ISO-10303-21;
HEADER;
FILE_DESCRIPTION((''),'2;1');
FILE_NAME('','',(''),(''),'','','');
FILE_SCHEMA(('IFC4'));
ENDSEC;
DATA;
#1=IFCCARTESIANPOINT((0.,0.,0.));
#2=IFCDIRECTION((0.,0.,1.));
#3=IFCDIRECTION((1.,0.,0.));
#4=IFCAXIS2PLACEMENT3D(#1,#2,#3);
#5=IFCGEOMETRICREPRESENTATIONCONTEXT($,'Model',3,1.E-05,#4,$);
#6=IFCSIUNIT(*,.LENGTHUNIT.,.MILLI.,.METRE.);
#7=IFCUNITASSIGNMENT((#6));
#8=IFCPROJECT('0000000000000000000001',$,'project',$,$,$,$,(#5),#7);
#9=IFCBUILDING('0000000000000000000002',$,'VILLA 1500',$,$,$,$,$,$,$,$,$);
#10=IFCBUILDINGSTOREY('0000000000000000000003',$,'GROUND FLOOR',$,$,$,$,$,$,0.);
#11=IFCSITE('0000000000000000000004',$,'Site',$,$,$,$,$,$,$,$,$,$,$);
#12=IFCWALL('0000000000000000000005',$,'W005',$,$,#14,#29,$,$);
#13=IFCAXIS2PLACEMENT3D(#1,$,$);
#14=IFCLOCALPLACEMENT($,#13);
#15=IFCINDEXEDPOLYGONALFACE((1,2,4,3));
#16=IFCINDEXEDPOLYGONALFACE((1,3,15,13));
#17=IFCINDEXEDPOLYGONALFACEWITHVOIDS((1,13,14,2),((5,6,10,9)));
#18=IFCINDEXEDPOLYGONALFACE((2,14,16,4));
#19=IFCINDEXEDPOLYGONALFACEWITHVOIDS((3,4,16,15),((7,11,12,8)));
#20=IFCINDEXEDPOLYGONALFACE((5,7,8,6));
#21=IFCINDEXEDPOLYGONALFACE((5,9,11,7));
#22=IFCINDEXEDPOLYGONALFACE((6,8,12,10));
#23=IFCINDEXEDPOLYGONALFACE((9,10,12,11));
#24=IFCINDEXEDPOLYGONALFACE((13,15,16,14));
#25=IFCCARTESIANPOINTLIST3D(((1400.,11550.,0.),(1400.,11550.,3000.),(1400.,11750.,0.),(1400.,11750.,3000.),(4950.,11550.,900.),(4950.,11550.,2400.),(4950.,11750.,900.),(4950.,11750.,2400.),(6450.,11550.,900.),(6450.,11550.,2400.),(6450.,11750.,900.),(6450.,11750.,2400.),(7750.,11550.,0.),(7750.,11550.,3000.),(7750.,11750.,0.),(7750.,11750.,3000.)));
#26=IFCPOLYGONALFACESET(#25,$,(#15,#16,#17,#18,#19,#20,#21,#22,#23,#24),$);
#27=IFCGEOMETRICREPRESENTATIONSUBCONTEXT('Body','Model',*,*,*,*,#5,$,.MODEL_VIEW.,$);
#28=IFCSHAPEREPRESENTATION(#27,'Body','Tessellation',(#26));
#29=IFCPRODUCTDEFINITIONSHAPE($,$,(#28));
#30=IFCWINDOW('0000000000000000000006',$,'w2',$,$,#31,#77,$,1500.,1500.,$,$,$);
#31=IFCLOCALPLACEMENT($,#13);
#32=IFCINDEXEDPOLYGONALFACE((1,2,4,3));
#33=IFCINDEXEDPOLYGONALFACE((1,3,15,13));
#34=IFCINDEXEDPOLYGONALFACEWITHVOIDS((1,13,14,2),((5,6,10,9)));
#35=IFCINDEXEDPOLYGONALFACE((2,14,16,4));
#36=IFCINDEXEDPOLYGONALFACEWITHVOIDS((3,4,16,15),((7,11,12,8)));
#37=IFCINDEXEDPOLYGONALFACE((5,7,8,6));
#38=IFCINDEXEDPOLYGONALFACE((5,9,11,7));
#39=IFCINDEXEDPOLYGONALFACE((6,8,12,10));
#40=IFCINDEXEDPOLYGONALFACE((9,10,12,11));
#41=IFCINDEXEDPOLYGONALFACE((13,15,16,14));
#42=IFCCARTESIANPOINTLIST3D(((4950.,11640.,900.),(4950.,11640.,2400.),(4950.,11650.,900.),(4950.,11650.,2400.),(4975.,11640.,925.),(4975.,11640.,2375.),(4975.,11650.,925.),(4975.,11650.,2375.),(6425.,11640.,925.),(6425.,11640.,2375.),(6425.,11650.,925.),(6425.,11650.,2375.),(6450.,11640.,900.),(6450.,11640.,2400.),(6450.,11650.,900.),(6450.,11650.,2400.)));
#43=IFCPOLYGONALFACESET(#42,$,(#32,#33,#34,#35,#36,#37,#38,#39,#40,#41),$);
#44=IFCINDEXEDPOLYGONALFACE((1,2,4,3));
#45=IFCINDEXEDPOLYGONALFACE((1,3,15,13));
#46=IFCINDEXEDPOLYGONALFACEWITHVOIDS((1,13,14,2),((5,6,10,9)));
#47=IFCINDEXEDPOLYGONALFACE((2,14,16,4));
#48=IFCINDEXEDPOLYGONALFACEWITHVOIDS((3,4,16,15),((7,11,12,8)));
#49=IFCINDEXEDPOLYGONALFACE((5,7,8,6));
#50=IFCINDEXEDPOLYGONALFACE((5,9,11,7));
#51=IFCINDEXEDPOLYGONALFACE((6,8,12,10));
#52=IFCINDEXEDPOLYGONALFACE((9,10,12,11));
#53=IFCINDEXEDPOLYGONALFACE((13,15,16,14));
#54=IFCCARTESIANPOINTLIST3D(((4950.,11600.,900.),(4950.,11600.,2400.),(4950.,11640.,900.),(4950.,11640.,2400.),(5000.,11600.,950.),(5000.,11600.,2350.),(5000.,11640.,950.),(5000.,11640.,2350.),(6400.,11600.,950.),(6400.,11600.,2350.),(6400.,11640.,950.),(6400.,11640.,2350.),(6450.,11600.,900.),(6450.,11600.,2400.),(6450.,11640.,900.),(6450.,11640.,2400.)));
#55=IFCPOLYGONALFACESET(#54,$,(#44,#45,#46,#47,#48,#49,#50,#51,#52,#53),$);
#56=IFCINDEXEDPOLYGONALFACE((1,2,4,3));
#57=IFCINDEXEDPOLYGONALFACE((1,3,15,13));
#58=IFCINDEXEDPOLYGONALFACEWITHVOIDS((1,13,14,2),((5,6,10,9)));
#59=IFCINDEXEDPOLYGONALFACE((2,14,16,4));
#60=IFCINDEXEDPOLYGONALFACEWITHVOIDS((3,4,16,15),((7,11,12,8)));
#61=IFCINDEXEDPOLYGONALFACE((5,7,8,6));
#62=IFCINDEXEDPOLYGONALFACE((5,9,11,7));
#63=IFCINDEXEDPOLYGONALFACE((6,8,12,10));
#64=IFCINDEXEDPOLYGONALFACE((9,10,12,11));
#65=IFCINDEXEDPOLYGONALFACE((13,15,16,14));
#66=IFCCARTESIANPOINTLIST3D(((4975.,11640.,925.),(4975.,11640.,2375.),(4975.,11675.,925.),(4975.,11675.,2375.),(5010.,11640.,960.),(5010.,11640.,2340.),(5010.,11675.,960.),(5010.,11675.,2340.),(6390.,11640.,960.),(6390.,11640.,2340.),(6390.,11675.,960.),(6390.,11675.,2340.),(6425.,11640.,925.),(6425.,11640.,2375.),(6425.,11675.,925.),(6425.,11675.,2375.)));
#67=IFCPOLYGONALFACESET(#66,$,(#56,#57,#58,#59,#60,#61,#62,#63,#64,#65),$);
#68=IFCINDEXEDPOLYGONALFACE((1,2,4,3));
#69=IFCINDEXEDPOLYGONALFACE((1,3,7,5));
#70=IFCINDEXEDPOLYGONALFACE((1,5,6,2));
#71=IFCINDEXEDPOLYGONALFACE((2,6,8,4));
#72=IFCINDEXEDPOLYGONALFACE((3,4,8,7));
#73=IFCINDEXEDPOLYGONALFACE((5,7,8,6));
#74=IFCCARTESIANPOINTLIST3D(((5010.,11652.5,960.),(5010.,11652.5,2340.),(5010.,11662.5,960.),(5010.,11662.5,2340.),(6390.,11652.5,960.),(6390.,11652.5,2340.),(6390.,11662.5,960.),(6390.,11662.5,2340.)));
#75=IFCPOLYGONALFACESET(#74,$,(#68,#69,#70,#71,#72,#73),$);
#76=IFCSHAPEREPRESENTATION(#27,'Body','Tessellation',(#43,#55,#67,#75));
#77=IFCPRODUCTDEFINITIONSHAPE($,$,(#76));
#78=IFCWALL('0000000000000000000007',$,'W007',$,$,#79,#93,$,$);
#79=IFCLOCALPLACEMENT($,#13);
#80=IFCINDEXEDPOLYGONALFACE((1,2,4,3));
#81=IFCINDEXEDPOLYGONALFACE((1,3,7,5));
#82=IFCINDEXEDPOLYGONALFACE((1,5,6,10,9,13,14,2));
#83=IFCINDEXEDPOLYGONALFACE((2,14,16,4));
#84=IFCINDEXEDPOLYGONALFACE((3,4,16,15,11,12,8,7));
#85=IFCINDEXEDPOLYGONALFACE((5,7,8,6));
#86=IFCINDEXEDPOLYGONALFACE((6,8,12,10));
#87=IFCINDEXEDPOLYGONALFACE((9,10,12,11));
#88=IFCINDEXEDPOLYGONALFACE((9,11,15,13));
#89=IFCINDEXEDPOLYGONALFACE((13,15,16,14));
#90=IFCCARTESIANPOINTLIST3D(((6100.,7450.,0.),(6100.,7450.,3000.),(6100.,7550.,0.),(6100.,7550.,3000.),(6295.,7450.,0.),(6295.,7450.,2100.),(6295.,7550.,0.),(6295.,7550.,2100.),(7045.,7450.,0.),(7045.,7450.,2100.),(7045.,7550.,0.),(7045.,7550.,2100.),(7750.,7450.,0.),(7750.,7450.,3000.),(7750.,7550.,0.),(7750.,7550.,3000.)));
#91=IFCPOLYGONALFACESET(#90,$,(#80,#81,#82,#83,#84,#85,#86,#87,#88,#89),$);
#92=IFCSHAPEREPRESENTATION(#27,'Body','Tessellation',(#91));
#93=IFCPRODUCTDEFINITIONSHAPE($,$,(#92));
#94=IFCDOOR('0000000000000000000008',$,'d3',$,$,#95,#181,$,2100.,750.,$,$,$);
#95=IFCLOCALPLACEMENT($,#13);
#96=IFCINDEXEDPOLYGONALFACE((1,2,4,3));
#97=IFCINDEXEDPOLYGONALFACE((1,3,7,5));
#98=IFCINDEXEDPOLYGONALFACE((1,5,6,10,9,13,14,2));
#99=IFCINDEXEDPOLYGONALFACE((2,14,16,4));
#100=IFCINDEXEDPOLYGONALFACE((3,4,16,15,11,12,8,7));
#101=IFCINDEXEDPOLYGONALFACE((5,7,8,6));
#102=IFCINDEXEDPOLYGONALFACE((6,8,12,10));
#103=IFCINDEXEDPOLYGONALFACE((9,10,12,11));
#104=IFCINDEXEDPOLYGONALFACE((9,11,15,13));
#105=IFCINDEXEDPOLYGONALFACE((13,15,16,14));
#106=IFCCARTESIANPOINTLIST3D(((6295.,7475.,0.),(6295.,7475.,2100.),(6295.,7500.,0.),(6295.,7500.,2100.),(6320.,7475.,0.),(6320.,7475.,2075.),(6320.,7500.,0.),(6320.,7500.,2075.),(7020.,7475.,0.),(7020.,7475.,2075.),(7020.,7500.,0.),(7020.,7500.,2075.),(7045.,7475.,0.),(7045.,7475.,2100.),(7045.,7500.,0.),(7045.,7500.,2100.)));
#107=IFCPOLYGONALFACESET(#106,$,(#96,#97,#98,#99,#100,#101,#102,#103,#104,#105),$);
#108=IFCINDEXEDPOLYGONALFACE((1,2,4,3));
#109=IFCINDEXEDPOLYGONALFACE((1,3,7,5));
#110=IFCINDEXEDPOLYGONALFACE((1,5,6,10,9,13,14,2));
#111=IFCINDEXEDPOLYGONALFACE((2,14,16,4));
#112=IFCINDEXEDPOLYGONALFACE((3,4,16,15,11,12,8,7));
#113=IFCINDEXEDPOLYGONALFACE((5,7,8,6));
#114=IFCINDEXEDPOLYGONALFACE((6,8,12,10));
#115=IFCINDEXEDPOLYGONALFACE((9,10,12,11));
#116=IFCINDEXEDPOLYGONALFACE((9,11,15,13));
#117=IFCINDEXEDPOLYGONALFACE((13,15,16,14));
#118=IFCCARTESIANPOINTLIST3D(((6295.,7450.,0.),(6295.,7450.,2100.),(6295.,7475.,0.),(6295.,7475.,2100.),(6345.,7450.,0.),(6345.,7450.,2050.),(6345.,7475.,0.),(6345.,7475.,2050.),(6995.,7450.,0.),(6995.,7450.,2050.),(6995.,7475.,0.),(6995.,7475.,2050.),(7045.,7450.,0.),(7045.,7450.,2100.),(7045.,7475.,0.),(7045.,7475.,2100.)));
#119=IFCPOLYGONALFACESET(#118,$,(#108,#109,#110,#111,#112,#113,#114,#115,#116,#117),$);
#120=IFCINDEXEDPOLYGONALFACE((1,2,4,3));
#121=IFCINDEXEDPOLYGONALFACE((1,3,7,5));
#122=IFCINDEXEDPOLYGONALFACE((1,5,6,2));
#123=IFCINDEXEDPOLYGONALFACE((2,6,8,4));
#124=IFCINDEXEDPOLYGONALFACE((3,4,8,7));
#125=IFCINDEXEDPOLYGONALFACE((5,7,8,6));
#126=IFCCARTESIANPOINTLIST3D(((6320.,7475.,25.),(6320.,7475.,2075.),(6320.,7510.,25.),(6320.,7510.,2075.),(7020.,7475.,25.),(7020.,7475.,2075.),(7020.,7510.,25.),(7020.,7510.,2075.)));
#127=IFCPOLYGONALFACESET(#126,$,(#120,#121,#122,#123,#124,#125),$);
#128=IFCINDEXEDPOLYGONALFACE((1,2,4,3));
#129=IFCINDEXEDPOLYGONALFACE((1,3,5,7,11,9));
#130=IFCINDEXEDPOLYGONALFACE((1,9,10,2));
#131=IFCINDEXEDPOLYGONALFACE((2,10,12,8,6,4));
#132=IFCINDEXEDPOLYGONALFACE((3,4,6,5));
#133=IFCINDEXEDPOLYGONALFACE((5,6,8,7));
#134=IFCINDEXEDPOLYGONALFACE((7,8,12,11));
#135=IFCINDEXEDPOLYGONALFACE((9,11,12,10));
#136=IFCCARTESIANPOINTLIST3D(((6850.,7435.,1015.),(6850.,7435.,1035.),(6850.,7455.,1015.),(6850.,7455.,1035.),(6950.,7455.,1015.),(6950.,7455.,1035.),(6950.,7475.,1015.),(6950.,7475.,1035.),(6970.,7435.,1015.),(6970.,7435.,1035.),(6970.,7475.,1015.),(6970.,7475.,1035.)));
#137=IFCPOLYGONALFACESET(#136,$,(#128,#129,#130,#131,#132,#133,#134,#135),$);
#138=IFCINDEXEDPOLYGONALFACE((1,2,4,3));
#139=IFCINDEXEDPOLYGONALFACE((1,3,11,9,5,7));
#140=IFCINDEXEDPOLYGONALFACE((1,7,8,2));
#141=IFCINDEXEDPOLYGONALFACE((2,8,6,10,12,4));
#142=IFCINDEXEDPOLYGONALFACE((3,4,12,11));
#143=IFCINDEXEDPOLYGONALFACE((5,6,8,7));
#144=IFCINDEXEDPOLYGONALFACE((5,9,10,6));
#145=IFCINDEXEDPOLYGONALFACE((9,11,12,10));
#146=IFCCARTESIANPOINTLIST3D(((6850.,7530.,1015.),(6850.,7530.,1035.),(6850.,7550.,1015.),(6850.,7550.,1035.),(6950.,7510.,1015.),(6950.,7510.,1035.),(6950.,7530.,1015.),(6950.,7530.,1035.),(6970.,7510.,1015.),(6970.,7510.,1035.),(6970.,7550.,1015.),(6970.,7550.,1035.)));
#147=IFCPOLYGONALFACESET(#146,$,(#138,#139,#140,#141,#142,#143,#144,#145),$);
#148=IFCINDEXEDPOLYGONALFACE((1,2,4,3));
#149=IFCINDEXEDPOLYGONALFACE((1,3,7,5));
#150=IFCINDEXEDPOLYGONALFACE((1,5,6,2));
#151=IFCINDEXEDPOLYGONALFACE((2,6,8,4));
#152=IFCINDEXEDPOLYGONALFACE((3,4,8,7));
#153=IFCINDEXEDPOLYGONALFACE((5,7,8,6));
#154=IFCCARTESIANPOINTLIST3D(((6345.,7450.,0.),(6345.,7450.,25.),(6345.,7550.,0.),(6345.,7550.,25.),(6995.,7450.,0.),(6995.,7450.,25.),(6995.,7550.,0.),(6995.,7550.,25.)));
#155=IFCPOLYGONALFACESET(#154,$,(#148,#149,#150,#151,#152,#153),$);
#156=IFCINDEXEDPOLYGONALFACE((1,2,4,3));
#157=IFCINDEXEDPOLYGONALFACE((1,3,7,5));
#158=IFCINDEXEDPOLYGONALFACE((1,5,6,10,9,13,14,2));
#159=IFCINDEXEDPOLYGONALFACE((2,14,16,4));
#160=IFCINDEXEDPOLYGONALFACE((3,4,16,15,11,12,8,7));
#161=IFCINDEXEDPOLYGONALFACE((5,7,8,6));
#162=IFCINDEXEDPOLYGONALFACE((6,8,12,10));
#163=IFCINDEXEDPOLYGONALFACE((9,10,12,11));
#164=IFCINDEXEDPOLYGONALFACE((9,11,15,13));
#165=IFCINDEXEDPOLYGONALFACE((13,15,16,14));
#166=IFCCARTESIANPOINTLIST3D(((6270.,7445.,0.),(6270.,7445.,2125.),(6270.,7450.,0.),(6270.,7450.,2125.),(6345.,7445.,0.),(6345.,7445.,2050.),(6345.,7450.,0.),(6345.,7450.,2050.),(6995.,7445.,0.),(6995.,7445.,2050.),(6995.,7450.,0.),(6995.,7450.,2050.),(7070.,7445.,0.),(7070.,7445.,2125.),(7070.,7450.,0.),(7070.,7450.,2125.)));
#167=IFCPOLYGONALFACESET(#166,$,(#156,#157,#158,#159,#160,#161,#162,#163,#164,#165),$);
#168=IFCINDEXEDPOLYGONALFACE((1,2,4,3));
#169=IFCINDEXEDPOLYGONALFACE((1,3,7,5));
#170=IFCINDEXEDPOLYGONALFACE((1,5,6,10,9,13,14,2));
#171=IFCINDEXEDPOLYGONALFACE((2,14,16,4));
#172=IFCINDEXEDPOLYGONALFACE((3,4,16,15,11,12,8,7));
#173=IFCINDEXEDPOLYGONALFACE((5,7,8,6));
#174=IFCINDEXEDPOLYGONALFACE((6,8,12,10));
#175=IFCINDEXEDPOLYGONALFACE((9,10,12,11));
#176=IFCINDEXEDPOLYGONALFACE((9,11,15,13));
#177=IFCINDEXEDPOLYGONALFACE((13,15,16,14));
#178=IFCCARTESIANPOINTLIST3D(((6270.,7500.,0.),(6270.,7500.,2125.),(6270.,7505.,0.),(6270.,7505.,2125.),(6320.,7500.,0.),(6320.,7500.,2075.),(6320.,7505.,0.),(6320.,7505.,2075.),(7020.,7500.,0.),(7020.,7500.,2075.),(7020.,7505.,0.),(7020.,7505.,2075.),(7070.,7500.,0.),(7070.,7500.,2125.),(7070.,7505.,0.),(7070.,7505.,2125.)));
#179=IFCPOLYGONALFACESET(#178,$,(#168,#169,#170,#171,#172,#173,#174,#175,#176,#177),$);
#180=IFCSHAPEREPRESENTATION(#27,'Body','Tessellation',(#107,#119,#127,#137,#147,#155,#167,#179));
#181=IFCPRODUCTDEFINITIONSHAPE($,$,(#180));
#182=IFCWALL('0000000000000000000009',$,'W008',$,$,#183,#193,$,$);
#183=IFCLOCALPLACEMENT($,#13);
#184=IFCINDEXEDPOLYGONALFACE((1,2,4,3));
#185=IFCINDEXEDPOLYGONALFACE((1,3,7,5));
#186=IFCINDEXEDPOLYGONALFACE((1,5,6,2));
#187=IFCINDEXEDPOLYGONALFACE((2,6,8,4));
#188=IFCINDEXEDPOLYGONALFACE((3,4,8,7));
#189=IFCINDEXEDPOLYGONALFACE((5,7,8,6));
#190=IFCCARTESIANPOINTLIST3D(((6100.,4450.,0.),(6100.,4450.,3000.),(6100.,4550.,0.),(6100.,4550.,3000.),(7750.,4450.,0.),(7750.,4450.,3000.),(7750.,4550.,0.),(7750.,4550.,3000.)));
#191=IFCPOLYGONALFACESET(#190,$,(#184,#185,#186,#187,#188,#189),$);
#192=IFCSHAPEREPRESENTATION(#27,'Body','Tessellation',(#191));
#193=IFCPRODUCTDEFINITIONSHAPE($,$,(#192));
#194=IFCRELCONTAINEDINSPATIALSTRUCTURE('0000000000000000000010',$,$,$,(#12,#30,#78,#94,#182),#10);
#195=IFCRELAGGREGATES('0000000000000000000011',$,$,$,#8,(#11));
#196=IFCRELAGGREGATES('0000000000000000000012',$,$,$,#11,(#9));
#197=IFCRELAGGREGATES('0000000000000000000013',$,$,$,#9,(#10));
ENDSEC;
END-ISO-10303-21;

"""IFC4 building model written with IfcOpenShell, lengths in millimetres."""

from ifc_helpers import new_model, si_unit, frame, origin_with_axes, place, context, subcontext, project, spatial, line, indexed_curve, outline, extrude, element, fill, save


model = new_model("IFC4")

# Units and contexts
model_context = context("Model", 3, precision=1e-05, world=origin_with_axes())
body_context = subcontext(model_context, "Body", "Model", "MODEL_VIEW")
ifc_project = project(units=[si_unit("LENGTHUNIT", "METRE", prefix="MILLI")], contexts=[model_context])

# Site, building, storey
site = spatial("IfcSite", under=ifc_project, Name="Site")
building = spatial("IfcBuilding", under=site, Name="VILLA 1500")
storey = spatial("IfcBuildingStorey", under=building, Name="GROUND FLOOR", Elevation=0.0)

# Wall, opening, window
wall_1_placement = place(None, frame((1400.0, 11650.0, 0.0), z_axis=(0.0, 0.0, 1.0), x_axis=(1.0, 0.0, 0.0)))
wall_1 = element("IfcWall", 1, at=wall_1_placement, inside=storey, Name="W005", context=body_context, shape_type="SweptSolid", body=[
    extrude(outline(indexed_curve([(0.0, 0.0), (0.0, 200.0), (6350.0, 200.0), (6350.0, 0.0), (0.0, 0.0)], self_intersect=False)), frame((0.0, -100.0, 0.0), z_axis=(0.0, 0.0, 1.0), x_axis=(1.0, 0.0, 0.0)), (0.0, 0.0, 1.0), 3000.0),
])
opening_1_placement = place(wall_1_placement, frame((3550.0, 0.0, 900.0), z_axis=(0.0, 0.0, 1.0), x_axis=(1.0, 0.0, 0.0)))
opening_1 = element("IfcOpeningElement", 2, at=opening_1_placement, cuts=wall_1, context=body_context, shape_type="SweptSolid", body=[
    extrude(outline(indexed_curve([(0.0, 0.0), (0.0, 300.0), (1500.0, 300.0), (1500.0, 0.0), (0.0, 0.0)], self_intersect=False)), frame((0.0, -150.0, 0.0), z_axis=(0.0, 0.0, 1.0), x_axis=(1.0, 0.0, 0.0)), (0.0, 0.0, 1.0), 1500.0),
])
window_1_placement = place(None, frame((4950.0, 11550.0, 900.0), z_axis=(0.0, 0.0, 1.0), x_axis=(1.0, 0.0, 0.0)))
window_1 = element("IfcWindow", 3, at=window_1_placement, inside=storey, Name="w2", OverallHeight=1500.0, OverallWidth=1500.0, context=body_context, shape_type="SweptSolid", body=[
    extrude(outline(indexed_curve([(0.0, 0.0), (1500.0, 0.0), (1500.0, 1500.0), (0.0, 1500.0)], segments=[line(1, 2, 3, 4, 1)]), holes=[indexed_curve([(25.0, 25.0), (1475.0, 25.0), (1475.0, 1475.0), (25.0, 1475.0)], segments=[line(1, 2, 3, 4, 1)])]), frame((0.0, 90.0, 0.0), z_axis=(0.0, -1.0, 0.0), x_axis=(1.0, 0.0, 0.0)), (0.0, 0.0, -1.0), 10.0),
    extrude(outline(indexed_curve([(0.0, 0.0), (1500.0, 0.0), (1500.0, 1500.0), (0.0, 1500.0)], segments=[line(1, 2, 3, 4, 1)]), holes=[indexed_curve([(50.0, 50.0), (1450.0, 50.0), (1450.0, 1450.0), (50.0, 1450.0)], segments=[line(1, 2, 3, 4, 1)])]), frame((0.0, 50.0, 0.0), z_axis=(0.0, -1.0, 0.0), x_axis=(1.0, 0.0, 0.0)), (0.0, 0.0, -1.0), 40.0),
    extrude(outline(indexed_curve([(0.0, 0.0), (1450.0, 0.0), (1450.0, 1450.0), (0.0, 1450.0)], segments=[line(1, 2, 3, 4, 1)]), holes=[indexed_curve([(35.0, 35.0), (1415.0, 35.0), (1415.0, 1415.0), (35.0, 1415.0)], segments=[line(1, 2, 3, 4, 1)])]), frame((25.0, 90.0, 25.0), z_axis=(0.0, -1.0, 0.0), x_axis=(1.0, 0.0, 0.0)), (0.0, 0.0, -1.0), 35.0),
    extrude(outline(indexed_curve([(35.0, 35.0), (1415.0, 35.0), (1415.0, 1415.0), (35.0, 1415.0)], segments=[line(1, 2, 3, 4, 1)])), frame((25.0, 102.5, 25.0), z_axis=(0.0, -1.0, 0.0), x_axis=(1.0, 0.0, 0.0)), (0.0, 0.0, -1.0), 10.0),
])
fill(opening_1, window_1)

# Wall, opening, door
wall_2_placement = place(None, frame((6100.0, 7500.0, 0.0), z_axis=(0.0, 0.0, 1.0), x_axis=(1.0, 0.0, 0.0)))
wall_2 = element("IfcWall", 4, at=wall_2_placement, inside=storey, Name="W007", context=body_context, shape_type="SweptSolid", body=[
    extrude(outline(indexed_curve([(0.0, 0.0), (0.0, 100.0), (1650.0, 100.0), (1650.0, 0.0), (0.0, 0.0)], self_intersect=False)), frame((0.0, -50.0, 0.0), z_axis=(0.0, 0.0, 1.0), x_axis=(1.0, 0.0, 0.0)), (0.0, 0.0, 1.0), 3000.0),
])
opening_2_placement = place(wall_2_placement, frame((195.0, 0.0, 0.0), z_axis=(0.0, 0.0, 1.0), x_axis=(1.0, 0.0, 0.0)))
opening_2 = element("IfcOpeningElement", 5, at=opening_2_placement, cuts=wall_2, context=body_context, shape_type="SweptSolid", body=[
    extrude(outline(indexed_curve([(0.0, 0.0), (0.0, 200.0), (750.0, 200.0), (750.0, 0.0), (0.0, 0.0)], self_intersect=False)), frame((0.0, -100.0, 0.0), z_axis=(0.0, 0.0, 1.0), x_axis=(1.0, 0.0, 0.0)), (0.0, 0.0, 1.0), 2100.0),
])
door_1_placement = place(None, frame((6295.0, 7450.0, 0.0), z_axis=(0.0, 0.0, 1.0), x_axis=(1.0, 0.0, 0.0)))
door_1 = element("IfcDoor", 6, at=door_1_placement, inside=storey, Name="d3", OverallHeight=2100.0, OverallWidth=750.0, context=body_context, shape_type="SweptSolid", body=[
    extrude(outline(indexed_curve([(0.0, 0.0), (0.0, 2100.0), (750.0, 2100.0), (750.0, 0.0), (725.0, 0.0), (725.0, 2075.0), (25.0, 2075.0), (25.0, 0.0)], segments=[line(1, 2, 3, 4, 5, 6, 7, 8, 1)])), frame((0.0, 25.0, 0.0), z_axis=(0.0, -1.0, 0.0), x_axis=(1.0, 0.0, 0.0)), (0.0, 0.0, -1.0), 25.0),
    extrude(outline(indexed_curve([(0.0, 0.0), (0.0, 2100.0), (750.0, 2100.0), (750.0, 0.0), (700.0, 0.0), (700.0, 2050.0), (50.0, 2050.0), (50.0, 0.0)], segments=[line(1, 2, 3, 4, 5, 6, 7, 8, 1)])), frame((0.0, 0.0, 0.0), z_axis=(0.0, -1.0, 0.0), x_axis=(1.0, 0.0, 0.0)), (0.0, 0.0, -1.0), 25.0),
    extrude(outline(indexed_curve([(0.0, 0.0), (700.0, 0.0), (700.0, 35.0), (0.0, 35.0)], segments=[line(1, 2, 3, 4, 1)])), frame((25.0, 25.0, 25.0), z_axis=(0.0, 0.0, 1.0), x_axis=(1.0, 0.0, 0.0)), (0.0, 0.0, 1.0), 2050.0),
    extrude(outline(indexed_curve([(0.0, 0.0), (0.0, -40.0), (-120.0, -40.0), (-120.0, -20.0), (-20.0, -20.0), (-20.0, 0.0)], segments=[line(1, 2, 3, 4, 5, 6, 1)])), frame((675.0, 25.0, 1015.0), z_axis=(0.0, 0.0, 1.0), x_axis=(1.0, 0.0, 0.0)), (0.0, 0.0, 1.0), 20.0),
    extrude(outline(indexed_curve([(0.0, 0.0), (0.0, 40.0), (-120.0, 40.0), (-120.0, 20.0), (-20.0, 20.0), (-20.0, 0.0)], segments=[line(1, 2, 3, 4, 5, 6, 1)])), frame((675.0, 60.0, 1015.0), z_axis=(0.0, 0.0, 1.0), x_axis=(1.0, 0.0, 0.0)), (0.0, 0.0, 1.0), 20.0),
    extrude(outline(indexed_curve([(0.0, 0.0), (650.0, 0.0), (650.0, 100.0), (0.0, 100.0)], segments=[line(1, 2, 3, 4, 1)])), frame((50.0, 0.0, 0.0), z_axis=(0.0, 0.0, 1.0), x_axis=(1.0, 0.0, 0.0)), (0.0, 0.0, 1.0), 25.0),
    extrude(outline(indexed_curve([(0.0, 0.0), (0.0, 2125.0), (800.0, 2125.0), (800.0, 0.0), (725.0, 0.0), (725.0, 2050.0), (75.0, 2050.0), (75.0, 0.0)], segments=[line(1, 2, 3, 4, 5, 6, 7, 8, 1)])), frame((-25.0, -5.0, 0.0), z_axis=(0.0, -1.0, 0.0), x_axis=(1.0, 0.0, 0.0)), (0.0, 0.0, -1.0), 5.0),
    extrude(outline(indexed_curve([(0.0, 0.0), (0.0, 2125.0), (800.0, 2125.0), (800.0, 0.0), (750.0, 0.0), (750.0, 2075.0), (50.0, 2075.0), (50.0, 0.0)], segments=[line(1, 2, 3, 4, 5, 6, 7, 8, 1)])), frame((-25.0, 50.0, 0.0), z_axis=(0.0, -1.0, 0.0), x_axis=(1.0, 0.0, 0.0)), (0.0, 0.0, -1.0), 5.0),
])
fill(opening_2, door_1)

# Wall
wall_3_placement = place(None, frame((6100.0, 4500.0, 0.0), z_axis=(0.0, 0.0, 1.0), x_axis=(1.0, 0.0, 0.0)))
element("IfcWall", 7, at=wall_3_placement, inside=storey, Name="W008", context=body_context, shape_type="SweptSolid", body=[
    extrude(outline(indexed_curve([(0.0, 0.0), (0.0, 100.0), (1650.0, 100.0), (1650.0, 0.0), (0.0, 0.0)], self_intersect=False)), frame((0.0, -50.0, 0.0), z_axis=(0.0, 0.0, 1.0), x_axis=(1.0, 0.0, 0.0)), (0.0, 0.0, 1.0), 3000.0),
])

save(model, "model.ifc")
